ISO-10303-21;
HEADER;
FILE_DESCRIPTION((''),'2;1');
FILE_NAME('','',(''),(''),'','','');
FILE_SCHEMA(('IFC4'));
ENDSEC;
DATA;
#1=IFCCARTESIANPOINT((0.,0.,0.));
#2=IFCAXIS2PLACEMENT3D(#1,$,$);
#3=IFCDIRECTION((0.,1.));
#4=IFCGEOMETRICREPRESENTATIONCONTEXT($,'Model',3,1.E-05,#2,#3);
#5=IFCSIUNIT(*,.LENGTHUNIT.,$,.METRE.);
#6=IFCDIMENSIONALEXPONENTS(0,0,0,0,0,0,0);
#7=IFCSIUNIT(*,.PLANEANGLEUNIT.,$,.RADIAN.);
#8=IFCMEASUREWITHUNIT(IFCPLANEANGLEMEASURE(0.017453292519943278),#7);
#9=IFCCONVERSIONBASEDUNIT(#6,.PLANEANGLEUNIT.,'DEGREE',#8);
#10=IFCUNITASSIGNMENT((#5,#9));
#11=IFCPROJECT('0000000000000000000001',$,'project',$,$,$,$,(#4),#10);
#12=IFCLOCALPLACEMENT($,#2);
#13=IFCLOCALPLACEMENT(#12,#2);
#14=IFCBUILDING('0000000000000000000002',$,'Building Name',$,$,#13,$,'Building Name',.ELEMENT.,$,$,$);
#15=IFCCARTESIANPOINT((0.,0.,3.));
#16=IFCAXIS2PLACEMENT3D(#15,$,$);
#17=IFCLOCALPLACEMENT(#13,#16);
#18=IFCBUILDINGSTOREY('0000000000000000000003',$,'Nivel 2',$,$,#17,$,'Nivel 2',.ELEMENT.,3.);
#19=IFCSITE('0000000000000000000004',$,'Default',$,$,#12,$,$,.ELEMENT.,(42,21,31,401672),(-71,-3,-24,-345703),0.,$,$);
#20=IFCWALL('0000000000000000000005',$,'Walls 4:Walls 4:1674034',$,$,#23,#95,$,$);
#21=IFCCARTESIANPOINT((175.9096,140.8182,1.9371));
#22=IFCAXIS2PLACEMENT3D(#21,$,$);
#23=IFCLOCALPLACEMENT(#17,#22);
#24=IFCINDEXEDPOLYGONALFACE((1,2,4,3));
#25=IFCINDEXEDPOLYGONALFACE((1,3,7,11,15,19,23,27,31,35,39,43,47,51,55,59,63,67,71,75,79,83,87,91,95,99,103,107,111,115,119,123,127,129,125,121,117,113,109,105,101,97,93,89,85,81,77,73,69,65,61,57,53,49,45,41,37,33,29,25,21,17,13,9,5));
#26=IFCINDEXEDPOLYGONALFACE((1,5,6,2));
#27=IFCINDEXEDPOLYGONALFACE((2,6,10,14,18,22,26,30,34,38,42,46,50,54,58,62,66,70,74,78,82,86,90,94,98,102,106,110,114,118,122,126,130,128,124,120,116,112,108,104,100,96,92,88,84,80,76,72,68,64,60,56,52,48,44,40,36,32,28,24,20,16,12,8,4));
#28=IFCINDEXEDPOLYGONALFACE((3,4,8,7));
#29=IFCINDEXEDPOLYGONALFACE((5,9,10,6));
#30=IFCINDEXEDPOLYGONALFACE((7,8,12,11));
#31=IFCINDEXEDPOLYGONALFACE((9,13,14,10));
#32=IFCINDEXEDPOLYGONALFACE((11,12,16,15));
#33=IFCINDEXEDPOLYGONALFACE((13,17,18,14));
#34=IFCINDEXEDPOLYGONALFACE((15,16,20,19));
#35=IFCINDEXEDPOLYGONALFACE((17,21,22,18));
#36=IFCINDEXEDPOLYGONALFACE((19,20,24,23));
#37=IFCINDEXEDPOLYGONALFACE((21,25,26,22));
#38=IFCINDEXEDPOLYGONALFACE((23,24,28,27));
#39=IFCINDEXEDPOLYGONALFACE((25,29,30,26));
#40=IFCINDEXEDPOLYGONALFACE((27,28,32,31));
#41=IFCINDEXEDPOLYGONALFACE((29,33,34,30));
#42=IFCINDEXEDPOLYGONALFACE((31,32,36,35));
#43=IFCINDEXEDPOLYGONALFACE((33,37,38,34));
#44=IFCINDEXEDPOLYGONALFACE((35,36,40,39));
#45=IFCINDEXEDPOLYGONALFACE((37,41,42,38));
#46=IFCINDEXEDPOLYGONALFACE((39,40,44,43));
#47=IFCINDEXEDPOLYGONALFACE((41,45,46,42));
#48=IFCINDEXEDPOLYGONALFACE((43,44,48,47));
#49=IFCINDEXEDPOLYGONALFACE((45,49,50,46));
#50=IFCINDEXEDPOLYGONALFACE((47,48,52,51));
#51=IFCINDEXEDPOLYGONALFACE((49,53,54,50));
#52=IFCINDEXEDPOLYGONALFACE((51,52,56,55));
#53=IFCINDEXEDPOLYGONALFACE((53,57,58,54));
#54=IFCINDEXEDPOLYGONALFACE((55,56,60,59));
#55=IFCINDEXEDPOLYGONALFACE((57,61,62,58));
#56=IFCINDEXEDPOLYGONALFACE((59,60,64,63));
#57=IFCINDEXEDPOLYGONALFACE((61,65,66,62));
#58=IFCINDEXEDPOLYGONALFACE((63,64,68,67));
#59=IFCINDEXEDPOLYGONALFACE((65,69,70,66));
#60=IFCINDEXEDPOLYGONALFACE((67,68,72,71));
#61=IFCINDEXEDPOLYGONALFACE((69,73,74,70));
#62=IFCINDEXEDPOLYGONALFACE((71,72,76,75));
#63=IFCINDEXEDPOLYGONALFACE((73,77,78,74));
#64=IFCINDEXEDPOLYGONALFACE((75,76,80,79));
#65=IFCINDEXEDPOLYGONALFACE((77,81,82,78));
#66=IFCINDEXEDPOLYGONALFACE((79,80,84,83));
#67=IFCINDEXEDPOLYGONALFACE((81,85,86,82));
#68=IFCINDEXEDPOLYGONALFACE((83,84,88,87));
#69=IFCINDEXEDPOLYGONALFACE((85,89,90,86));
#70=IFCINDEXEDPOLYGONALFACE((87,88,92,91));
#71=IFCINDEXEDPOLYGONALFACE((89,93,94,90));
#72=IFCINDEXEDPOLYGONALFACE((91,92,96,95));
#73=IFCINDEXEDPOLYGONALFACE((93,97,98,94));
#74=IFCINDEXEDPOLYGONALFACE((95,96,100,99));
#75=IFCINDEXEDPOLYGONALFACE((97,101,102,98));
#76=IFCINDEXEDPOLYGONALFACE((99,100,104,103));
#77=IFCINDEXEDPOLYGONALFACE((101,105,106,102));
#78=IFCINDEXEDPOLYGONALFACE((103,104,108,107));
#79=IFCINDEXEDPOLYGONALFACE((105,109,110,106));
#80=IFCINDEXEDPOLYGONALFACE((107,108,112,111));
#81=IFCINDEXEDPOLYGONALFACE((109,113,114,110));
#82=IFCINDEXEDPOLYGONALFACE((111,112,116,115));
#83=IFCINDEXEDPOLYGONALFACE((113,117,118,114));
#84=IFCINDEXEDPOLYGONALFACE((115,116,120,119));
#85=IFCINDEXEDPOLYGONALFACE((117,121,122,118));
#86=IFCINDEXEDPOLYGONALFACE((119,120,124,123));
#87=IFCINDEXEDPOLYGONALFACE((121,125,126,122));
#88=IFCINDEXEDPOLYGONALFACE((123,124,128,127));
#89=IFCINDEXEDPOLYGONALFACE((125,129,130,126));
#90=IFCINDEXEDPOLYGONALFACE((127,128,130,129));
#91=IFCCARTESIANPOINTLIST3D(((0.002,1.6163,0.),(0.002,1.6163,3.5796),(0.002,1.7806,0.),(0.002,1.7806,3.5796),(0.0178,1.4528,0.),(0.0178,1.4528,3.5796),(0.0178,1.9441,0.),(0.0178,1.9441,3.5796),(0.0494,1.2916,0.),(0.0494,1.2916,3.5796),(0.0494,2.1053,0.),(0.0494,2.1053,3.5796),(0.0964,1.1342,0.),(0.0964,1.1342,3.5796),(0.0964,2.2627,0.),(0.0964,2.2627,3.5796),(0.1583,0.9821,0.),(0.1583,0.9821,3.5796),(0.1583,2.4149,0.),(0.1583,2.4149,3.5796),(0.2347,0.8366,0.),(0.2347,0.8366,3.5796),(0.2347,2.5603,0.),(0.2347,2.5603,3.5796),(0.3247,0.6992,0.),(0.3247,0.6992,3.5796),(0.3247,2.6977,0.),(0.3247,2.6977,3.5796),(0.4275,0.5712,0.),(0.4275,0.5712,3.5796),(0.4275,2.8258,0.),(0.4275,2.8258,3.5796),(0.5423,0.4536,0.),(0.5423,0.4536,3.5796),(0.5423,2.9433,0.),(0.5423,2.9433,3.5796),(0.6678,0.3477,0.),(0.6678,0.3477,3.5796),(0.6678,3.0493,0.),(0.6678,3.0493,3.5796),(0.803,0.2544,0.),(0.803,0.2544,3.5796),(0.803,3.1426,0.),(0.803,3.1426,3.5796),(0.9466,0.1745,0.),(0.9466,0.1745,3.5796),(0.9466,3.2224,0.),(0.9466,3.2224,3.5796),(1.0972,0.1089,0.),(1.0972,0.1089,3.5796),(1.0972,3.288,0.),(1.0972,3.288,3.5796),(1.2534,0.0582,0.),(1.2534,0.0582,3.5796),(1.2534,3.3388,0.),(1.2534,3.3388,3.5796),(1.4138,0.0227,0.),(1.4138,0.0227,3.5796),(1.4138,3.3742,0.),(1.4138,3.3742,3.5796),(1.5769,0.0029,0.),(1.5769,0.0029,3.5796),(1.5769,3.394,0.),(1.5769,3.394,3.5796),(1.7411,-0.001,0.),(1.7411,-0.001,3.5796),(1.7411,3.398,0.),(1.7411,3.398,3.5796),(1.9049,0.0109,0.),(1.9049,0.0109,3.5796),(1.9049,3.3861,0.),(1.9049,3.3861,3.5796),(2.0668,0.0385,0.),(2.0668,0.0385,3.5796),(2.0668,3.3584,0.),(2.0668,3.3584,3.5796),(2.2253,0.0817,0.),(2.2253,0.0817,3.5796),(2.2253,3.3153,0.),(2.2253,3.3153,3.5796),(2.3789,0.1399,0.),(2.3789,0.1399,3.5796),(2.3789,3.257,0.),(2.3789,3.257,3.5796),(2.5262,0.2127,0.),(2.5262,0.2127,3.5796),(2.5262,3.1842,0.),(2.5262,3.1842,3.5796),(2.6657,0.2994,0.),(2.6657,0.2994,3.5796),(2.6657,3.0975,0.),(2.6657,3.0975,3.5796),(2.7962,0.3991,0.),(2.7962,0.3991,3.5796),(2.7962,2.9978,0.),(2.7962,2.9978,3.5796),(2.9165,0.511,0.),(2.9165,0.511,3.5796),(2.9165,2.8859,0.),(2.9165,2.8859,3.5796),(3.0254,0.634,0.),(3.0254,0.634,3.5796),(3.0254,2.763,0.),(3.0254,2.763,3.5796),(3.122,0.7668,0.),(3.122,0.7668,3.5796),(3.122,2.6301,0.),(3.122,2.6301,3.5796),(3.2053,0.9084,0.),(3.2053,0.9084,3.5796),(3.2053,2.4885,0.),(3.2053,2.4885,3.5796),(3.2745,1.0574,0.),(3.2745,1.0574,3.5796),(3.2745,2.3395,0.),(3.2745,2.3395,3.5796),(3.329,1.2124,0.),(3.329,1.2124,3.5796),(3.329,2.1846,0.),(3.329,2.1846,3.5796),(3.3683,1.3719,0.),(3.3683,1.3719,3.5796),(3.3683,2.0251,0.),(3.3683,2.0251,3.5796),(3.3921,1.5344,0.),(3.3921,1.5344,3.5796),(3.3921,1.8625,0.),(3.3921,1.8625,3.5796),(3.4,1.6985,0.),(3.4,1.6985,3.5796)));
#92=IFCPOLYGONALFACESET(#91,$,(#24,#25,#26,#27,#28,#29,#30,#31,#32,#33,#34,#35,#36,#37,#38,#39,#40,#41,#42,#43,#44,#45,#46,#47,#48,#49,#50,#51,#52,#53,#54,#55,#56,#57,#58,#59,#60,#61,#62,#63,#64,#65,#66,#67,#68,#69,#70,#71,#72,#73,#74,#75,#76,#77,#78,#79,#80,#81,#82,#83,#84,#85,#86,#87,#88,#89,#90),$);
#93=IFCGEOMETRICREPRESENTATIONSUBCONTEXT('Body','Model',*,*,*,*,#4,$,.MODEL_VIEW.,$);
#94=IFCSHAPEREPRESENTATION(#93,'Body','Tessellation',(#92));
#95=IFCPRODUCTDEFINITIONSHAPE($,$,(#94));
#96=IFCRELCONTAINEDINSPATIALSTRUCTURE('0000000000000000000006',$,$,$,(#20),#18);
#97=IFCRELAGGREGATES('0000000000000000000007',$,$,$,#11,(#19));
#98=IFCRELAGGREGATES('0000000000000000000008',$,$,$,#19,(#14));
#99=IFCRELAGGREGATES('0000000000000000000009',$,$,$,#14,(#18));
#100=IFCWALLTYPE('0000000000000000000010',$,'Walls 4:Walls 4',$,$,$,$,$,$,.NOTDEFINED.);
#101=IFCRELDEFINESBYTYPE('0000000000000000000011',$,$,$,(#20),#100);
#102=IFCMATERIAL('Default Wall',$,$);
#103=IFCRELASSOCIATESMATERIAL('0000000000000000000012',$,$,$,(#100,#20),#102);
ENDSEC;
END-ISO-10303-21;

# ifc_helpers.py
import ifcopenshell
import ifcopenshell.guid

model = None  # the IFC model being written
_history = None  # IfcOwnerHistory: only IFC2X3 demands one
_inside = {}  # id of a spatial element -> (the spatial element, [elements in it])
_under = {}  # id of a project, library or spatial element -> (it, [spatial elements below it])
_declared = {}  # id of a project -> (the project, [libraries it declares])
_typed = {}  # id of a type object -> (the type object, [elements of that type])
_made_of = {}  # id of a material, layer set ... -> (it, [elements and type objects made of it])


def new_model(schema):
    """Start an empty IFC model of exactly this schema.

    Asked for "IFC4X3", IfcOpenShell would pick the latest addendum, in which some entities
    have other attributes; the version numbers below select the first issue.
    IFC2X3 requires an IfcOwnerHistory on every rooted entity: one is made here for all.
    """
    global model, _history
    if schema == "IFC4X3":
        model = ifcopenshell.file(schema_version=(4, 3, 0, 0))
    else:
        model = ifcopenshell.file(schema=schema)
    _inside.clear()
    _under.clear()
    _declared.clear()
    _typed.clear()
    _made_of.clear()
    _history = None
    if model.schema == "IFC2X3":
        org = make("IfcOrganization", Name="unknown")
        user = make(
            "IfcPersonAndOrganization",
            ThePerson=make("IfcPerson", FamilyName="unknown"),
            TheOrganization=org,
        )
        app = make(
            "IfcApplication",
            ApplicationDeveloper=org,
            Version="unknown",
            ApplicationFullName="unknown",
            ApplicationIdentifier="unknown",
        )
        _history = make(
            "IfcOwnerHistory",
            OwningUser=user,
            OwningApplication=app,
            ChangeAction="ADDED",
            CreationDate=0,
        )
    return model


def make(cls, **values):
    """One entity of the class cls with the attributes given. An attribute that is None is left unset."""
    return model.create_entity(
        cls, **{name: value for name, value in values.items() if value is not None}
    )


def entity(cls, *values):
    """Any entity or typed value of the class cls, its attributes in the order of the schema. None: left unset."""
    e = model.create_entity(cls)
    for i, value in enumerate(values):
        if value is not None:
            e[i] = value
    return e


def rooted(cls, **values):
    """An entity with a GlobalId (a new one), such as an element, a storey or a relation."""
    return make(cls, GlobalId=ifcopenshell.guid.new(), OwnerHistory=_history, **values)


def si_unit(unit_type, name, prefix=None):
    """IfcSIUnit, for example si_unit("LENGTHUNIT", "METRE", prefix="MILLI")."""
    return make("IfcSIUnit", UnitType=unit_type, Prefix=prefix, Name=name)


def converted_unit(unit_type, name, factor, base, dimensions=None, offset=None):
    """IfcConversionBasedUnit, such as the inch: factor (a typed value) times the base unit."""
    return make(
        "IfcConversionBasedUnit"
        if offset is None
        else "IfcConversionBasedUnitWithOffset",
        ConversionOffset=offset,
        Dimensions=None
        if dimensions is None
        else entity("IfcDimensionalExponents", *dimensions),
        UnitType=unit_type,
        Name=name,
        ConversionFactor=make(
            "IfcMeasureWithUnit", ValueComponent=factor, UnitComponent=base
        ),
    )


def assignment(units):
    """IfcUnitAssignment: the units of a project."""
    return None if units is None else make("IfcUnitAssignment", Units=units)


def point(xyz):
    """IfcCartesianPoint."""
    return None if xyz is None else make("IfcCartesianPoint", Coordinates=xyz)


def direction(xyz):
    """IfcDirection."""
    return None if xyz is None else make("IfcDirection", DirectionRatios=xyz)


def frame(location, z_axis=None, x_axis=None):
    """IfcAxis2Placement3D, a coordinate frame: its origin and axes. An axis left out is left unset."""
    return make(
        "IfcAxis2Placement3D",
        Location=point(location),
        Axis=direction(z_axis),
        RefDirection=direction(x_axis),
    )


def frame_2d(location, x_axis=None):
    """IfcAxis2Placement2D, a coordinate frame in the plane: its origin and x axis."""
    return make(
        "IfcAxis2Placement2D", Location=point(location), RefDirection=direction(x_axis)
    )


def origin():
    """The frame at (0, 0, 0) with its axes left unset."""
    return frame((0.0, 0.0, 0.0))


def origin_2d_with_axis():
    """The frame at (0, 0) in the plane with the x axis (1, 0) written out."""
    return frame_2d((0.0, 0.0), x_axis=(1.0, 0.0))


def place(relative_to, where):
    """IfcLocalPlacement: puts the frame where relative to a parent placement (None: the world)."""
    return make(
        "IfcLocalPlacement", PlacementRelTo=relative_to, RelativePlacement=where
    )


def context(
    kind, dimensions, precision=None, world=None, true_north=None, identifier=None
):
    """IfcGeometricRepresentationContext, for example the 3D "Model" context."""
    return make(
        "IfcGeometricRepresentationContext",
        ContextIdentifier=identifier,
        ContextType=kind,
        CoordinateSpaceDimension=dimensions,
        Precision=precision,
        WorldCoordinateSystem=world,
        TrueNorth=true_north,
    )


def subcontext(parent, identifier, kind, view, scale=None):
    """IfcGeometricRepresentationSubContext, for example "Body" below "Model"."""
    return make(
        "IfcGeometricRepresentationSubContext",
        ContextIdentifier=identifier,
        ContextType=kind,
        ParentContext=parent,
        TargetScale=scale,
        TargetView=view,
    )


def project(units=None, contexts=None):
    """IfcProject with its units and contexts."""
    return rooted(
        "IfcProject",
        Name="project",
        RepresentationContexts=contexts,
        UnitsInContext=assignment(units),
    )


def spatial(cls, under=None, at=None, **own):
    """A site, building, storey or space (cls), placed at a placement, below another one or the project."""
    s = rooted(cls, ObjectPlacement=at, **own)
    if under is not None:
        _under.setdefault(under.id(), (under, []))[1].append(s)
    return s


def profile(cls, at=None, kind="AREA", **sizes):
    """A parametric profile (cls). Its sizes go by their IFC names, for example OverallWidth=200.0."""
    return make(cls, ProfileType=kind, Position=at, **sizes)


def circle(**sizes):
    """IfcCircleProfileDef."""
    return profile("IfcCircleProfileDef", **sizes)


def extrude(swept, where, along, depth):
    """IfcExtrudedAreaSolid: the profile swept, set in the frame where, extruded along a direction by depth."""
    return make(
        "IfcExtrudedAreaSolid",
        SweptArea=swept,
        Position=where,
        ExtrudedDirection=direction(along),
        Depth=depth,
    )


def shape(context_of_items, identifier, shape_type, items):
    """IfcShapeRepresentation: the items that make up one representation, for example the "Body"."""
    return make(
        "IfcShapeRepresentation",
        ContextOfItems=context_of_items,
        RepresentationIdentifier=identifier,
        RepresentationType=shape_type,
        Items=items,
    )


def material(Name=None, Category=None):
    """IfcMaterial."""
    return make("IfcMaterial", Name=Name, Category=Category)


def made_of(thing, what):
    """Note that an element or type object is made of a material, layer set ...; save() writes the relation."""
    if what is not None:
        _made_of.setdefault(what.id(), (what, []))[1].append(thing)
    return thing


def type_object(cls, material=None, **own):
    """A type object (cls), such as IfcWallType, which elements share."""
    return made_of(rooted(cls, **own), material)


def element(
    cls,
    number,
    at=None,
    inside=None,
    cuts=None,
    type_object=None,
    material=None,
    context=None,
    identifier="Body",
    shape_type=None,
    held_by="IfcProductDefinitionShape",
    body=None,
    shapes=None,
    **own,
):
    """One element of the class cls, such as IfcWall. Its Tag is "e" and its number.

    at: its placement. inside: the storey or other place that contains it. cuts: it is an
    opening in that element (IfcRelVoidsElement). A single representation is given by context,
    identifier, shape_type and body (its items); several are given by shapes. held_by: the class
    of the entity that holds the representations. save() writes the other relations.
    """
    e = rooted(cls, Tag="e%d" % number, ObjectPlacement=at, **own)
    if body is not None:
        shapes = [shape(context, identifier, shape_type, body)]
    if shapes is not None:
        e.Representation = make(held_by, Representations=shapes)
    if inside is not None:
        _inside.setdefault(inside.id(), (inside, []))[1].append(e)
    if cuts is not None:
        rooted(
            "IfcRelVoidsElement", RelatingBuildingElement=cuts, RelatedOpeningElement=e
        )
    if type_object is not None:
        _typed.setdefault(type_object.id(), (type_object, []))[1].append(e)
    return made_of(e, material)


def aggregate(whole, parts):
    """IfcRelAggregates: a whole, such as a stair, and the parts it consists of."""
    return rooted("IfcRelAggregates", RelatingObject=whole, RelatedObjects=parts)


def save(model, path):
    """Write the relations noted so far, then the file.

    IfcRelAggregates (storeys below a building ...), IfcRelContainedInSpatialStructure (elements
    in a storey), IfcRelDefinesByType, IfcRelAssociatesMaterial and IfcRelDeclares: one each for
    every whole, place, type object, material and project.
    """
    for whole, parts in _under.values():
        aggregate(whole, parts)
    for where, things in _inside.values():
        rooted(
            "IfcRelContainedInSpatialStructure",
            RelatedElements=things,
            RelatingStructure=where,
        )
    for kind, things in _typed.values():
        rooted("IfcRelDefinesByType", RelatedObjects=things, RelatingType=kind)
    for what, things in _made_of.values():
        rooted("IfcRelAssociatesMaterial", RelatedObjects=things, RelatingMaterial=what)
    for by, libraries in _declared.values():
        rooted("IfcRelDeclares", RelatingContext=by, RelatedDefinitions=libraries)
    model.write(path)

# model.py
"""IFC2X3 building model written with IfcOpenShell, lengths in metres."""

from ifc_helpers import new_model, entity, si_unit, converted_unit, direction, frame, origin, origin_2d_with_axis, place, context, subcontext, project, spatial, circle, extrude, material, type_object, element, save


model = new_model("IFC2X3")

# Units and contexts
model_context = context("Model", 3, precision=1e-05, world=origin(), true_north=direction((0.0, 1.0)))
body_context = subcontext(model_context, "Body", "Model", "MODEL_VIEW")
ifc_project = project(units=[si_unit("LENGTHUNIT", "METRE"), converted_unit("PLANEANGLEUNIT", "DEGREE", entity("IfcPlaneAngleMeasure", 0.017453292519943278), si_unit("PLANEANGLEUNIT", "RADIAN"), dimensions=[0, 0, 0, 0, 0, 0, 0])], contexts=[model_context])

# Site, building, storey
site_placement = place(None, origin())
site = spatial("IfcSite", under=ifc_project, at=site_placement, Name="Default", CompositionType="ELEMENT", RefLatitude=(42, 21, 31, 401672), RefLongitude=(-71, -3, -24, -345703), RefElevation=0.0)
building_placement = place(site_placement, origin())
building = spatial("IfcBuilding", under=site, at=building_placement, Name="Building Name", LongName="Building Name", CompositionType="ELEMENT")
storey_placement = place(building_placement, frame((0.0, 0.0, 3.0)))
storey = spatial("IfcBuildingStorey", under=building, at=storey_placement, Name="Nivel 2", LongName="Nivel 2", CompositionType="ELEMENT", Elevation=3.0)

# Wall
ifc_material_1 = material(Name="Default Wall")
wall_type_1 = type_object("IfcWallType", Name="Walls 4:Walls 4", PredefinedType="NOTDEFINED", material=ifc_material_1)
wall_1_placement = place(storey_placement, frame((175.9096, 140.8182, 1.9371)))
element("IfcWall", 1, at=wall_1_placement, inside=storey, type_object=wall_type_1, material=ifc_material_1, Name="Walls 4:Walls 4:1674034", context=body_context, shape_type="SweptSolid", body=[
    extrude(circle(Radius=1.7, at=origin_2d_with_axis()), frame((1.7, 1.6985, 0.0)), (0.0, 0.0, 1.0), 3.5796),
])

save(model, "model.ifc")
